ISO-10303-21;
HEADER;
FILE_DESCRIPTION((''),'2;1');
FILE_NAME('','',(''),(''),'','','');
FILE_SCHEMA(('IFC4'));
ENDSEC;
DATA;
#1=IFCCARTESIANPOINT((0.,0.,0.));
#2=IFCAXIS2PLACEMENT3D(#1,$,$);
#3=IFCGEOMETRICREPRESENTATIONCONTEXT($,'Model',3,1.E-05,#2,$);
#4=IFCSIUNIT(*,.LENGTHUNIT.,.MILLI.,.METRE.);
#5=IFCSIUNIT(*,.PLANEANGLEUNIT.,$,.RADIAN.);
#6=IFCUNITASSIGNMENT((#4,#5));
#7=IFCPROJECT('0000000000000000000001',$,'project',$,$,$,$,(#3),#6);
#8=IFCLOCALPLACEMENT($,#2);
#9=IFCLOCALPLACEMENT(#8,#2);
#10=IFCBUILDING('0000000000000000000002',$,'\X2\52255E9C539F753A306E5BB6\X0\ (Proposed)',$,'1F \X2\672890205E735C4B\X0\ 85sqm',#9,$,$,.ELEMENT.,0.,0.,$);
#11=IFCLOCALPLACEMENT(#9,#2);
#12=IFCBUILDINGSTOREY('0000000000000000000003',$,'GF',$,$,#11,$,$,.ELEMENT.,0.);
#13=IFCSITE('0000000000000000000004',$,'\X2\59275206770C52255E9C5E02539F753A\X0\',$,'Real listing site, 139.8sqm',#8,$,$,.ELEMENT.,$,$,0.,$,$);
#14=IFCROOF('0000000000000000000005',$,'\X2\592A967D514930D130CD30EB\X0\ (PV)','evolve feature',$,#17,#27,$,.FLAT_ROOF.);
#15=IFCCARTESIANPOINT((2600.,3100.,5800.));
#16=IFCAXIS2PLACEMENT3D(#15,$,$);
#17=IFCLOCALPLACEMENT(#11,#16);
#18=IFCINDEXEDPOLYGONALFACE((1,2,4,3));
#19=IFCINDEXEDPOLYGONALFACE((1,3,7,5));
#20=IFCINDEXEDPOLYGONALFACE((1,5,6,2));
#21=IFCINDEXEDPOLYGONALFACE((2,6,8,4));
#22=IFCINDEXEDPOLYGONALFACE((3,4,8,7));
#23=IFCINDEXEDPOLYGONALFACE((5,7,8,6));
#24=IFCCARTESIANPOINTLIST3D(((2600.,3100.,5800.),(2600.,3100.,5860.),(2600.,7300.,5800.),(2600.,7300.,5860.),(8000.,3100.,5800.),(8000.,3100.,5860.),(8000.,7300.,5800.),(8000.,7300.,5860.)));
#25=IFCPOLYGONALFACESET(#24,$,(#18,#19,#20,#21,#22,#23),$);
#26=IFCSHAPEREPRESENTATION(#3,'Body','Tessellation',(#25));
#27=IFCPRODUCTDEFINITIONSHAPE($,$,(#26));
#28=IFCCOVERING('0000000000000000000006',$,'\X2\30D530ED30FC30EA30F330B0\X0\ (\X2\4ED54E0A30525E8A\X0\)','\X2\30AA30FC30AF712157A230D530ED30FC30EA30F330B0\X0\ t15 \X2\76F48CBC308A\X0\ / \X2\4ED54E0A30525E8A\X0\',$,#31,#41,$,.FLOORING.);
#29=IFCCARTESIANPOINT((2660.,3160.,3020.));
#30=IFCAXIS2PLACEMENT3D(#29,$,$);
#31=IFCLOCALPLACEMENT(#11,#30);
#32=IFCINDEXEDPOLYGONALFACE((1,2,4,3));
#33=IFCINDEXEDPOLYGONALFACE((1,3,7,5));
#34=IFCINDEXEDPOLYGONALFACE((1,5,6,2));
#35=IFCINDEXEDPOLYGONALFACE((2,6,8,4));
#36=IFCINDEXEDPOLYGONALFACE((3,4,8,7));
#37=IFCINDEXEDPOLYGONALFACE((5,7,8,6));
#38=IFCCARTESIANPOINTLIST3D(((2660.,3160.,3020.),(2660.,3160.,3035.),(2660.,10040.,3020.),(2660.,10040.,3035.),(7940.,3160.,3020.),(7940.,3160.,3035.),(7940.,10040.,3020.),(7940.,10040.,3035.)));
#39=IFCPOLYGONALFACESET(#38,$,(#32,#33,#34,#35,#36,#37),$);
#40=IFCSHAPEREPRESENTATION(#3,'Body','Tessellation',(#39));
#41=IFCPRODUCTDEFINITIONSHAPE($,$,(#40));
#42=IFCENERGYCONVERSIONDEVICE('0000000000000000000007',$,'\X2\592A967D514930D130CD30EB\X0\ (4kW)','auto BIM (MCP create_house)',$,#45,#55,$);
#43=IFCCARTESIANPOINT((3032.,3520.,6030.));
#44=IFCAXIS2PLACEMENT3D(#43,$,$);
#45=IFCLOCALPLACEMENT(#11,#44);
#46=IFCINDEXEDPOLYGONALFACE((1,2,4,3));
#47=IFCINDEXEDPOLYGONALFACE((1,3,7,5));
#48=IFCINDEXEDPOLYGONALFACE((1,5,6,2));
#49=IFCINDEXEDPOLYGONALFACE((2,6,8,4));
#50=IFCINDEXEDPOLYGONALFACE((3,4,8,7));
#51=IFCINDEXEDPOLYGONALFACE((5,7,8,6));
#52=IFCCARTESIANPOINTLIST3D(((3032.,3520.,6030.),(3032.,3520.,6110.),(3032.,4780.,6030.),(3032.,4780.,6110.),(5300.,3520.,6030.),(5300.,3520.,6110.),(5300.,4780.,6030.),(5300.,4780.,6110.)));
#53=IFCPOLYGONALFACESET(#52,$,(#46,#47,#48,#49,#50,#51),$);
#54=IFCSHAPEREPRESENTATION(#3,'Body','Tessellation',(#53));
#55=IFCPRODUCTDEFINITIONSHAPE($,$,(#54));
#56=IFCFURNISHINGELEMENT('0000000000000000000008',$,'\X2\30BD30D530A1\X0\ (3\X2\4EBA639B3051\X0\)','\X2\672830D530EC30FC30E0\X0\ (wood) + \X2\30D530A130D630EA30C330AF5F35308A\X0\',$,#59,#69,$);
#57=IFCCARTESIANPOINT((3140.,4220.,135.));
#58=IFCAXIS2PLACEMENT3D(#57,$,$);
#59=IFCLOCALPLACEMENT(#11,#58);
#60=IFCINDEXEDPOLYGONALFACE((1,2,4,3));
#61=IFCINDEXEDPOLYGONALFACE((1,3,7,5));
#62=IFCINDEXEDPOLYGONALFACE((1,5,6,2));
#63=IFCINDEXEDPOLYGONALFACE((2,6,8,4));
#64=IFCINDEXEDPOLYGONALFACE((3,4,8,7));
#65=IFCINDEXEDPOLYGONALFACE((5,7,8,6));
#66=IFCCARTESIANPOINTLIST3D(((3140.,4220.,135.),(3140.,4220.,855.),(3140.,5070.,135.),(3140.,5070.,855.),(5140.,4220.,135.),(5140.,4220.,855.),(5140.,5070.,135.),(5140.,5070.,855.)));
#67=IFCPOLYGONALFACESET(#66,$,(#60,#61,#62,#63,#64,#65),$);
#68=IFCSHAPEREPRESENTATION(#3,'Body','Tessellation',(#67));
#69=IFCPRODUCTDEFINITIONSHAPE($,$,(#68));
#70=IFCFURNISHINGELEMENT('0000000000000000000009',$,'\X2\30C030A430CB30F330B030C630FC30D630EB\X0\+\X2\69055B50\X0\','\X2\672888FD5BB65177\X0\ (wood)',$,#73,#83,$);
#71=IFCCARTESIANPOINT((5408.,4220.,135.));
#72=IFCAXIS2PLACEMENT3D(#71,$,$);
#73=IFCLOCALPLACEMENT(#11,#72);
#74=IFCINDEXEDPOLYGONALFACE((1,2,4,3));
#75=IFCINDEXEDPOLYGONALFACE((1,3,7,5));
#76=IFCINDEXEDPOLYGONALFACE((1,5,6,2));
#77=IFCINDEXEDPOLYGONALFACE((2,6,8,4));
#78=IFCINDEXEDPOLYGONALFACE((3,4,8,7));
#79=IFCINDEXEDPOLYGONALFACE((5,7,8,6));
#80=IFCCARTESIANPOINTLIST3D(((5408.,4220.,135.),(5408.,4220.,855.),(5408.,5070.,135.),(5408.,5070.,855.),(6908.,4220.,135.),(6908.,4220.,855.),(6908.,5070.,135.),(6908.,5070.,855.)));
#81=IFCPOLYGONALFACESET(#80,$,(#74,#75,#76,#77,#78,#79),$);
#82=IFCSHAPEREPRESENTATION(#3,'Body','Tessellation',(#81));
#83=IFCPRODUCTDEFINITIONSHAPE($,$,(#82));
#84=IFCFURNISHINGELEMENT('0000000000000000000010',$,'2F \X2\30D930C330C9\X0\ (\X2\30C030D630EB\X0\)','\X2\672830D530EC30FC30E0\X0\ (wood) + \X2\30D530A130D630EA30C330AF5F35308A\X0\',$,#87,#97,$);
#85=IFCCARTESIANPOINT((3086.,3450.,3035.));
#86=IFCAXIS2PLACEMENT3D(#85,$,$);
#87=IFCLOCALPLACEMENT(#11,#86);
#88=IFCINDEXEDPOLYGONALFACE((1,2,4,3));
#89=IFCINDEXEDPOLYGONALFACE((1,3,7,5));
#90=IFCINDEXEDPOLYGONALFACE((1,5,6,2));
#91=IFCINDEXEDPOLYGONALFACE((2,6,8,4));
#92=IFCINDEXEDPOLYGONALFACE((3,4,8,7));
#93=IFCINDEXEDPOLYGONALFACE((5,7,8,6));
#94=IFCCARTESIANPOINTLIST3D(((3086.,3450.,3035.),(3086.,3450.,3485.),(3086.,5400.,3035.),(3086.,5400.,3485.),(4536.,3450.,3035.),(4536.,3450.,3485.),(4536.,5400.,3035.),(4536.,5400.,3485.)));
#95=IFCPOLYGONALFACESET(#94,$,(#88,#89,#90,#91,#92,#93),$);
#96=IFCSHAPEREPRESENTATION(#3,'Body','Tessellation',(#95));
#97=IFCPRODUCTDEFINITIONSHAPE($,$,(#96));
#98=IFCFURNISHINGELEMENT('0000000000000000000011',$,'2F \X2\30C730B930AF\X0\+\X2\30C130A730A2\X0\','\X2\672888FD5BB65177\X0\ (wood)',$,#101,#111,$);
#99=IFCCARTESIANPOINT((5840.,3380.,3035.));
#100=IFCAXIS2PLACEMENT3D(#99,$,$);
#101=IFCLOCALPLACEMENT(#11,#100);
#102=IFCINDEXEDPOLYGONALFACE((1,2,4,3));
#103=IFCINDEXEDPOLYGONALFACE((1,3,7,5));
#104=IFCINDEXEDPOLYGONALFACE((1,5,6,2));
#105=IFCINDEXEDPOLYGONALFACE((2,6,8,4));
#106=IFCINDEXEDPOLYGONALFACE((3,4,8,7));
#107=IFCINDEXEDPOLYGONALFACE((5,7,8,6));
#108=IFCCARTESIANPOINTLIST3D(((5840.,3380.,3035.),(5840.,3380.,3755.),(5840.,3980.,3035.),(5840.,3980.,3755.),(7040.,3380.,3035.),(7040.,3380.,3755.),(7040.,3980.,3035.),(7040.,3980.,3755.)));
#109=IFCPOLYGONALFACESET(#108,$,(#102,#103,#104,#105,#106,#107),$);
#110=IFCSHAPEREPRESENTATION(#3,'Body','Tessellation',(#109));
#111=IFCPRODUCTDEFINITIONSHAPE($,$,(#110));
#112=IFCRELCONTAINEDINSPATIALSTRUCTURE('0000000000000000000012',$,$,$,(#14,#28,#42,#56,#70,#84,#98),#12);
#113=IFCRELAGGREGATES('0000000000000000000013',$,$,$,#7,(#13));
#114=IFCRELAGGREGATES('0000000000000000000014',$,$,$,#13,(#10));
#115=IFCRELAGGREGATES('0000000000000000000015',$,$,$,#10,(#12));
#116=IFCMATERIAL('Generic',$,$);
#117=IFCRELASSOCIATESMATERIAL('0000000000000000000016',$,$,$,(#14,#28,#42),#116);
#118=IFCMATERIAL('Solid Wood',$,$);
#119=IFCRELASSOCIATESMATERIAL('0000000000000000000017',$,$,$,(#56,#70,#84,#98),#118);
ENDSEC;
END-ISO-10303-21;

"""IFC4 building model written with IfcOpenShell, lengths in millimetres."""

from ifc_helpers import new_model, si_unit, frame, frame_2d, origin, place, context, project, spatial, rectangle, extrude, material, element, save


model = new_model("IFC4")

# Units and contexts
model_context = context("Model", 3, precision=1e-05, world=origin())
ifc_project = project(units=[si_unit("LENGTHUNIT", "METRE", prefix="MILLI"), si_unit("PLANEANGLEUNIT", "RADIAN")], contexts=[model_context])

# Site, building, storey
site_placement = place(None, origin())
site = spatial("IfcSite", under=ifc_project, at=site_placement, Name="大分県別府市原町", ObjectType="Real listing site, 139.8sqm", CompositionType="ELEMENT", RefElevation=0.0)
building_placement = place(site_placement, origin())
building = spatial("IfcBuilding", under=site, at=building_placement, Name="別府原町の家 (Proposed)", ObjectType="1F 木造平屋 85sqm", CompositionType="ELEMENT", ElevationOfRefHeight=0.0, ElevationOfTerrain=0.0)
storey_placement = place(building_placement, origin())
storey = spatial("IfcBuildingStorey", under=building, at=storey_placement, Name="GF", CompositionType="ELEMENT", Elevation=0.0)

# Shared definitions
ifc_material_1 = material(Name="Solid Wood")

# Shared definitions
ifc_material_2 = material(Name="Generic")

# Roof
roof_1_placement = place(storey_placement, frame((2600.0, 3100.0, 5800.0)))
element("IfcRoof", 1, at=roof_1_placement, inside=storey, material=ifc_material_2, Name="太陽光パネル (PV)", Description="evolve feature", PredefinedType="FLAT_ROOF", context=model_context, shape_type="SweptSolid", body=[
    extrude(rectangle(XDim=5400.0, YDim=4200.0, at=frame_2d((2700.0, 2100.0))), frame((2600.0, 3100.0, 5800.0)), (0.0, 0.0, 1.0), 60.0),
])

# Covering
covering_placement = place(storey_placement, frame((2660.0, 3160.0, 3020.0)))
element("IfcCovering", 2, at=covering_placement, inside=storey, material=ifc_material_2, Name="フローリング (仕上げ床)", Description="オーク無垢フローリング t15 直貼り / 仕上げ床", PredefinedType="FLOORING", context=model_context, shape_type="SweptSolid", body=[
    extrude(rectangle(XDim=5280.0, YDim=6880.0, at=frame_2d((2640.0, 3440.0))), frame((2660.0, 3160.0, 3020.0)), (0.0, 0.0, 1.0), 15.0),
])

# Energy conversion device
energy_conversion_device_placement = place(storey_placement, frame((3032.0, 3520.0, 6030.0)))
element("IfcEnergyConversionDevice", 3, at=energy_conversion_device_placement, inside=storey, material=ifc_material_2, Name="太陽光パネル (4kW)", Description="auto BIM (MCP create_house)", context=model_context, shape_type="SweptSolid", body=[
    extrude(rectangle(XDim=2268.0, YDim=1260.0, at=frame_2d((1134.0, 630.0))), frame((3032.0, 3520.0, 6030.0)), (0.0, 0.0, 1.0), 80.0),
])

# Furnishing elements
furnishing_1_placement = place(storey_placement, frame((3140.0, 4220.0, 135.0)))
element("IfcFurnishingElement", 4, at=furnishing_1_placement, inside=storey, material=ifc_material_1, Name="ソファ (3人掛け)", Description="木フレーム (wood) + ファブリック張り", context=model_context, shape_type="SweptSolid", body=[
    extrude(rectangle(XDim=2000.0, YDim=850.0, at=frame_2d((1000.0, 425.0))), frame((3140.0, 4220.0, 135.0)), (0.0, 0.0, 1.0), 720.0),
])
furnishing_2_placement = place(storey_placement, frame((5408.0, 4220.0, 135.0)))
element("IfcFurnishingElement", 5, at=furnishing_2_placement, inside=storey, material=ifc_material_1, Name="ダイニングテーブル+椅子", Description="木製家具 (wood)", context=model_context, shape_type="SweptSolid", body=[
    extrude(rectangle(XDim=1500.0, YDim=850.0, at=frame_2d((750.0, 425.0))), frame((5408.0, 4220.0, 135.0)), (0.0, 0.0, 1.0), 720.0),
])
furnishing_3_placement = place(storey_placement, frame((3086.0, 3450.0, 3035.0)))
element("IfcFurnishingElement", 6, at=furnishing_3_placement, inside=storey, material=ifc_material_1, Name="2F ベッド (ダブル)", Description="木フレーム (wood) + ファブリック張り", context=model_context, shape_type="SweptSolid", body=[
    extrude(rectangle(XDim=1450.0, YDim=1950.0, at=frame_2d((725.0, 975.0))), frame((3086.0, 3450.0, 3035.0)), (0.0, 0.0, 1.0), 450.0),
])
furnishing_4_placement = place(storey_placement, frame((5840.0, 3380.0, 3035.0)))
element("IfcFurnishingElement", 7, at=furnishing_4_placement, inside=storey, material=ifc_material_1, Name="2F デスク+チェア", Description="木製家具 (wood)", context=model_context, shape_type="SweptSolid", body=[
    extrude(rectangle(XDim=1200.0, YDim=600.0, at=frame_2d((600.0, 300.0))), frame((5840.0, 3380.0, 3035.0)), (0.0, 0.0, 1.0), 720.0),
])

save(model, "model.ifc")
